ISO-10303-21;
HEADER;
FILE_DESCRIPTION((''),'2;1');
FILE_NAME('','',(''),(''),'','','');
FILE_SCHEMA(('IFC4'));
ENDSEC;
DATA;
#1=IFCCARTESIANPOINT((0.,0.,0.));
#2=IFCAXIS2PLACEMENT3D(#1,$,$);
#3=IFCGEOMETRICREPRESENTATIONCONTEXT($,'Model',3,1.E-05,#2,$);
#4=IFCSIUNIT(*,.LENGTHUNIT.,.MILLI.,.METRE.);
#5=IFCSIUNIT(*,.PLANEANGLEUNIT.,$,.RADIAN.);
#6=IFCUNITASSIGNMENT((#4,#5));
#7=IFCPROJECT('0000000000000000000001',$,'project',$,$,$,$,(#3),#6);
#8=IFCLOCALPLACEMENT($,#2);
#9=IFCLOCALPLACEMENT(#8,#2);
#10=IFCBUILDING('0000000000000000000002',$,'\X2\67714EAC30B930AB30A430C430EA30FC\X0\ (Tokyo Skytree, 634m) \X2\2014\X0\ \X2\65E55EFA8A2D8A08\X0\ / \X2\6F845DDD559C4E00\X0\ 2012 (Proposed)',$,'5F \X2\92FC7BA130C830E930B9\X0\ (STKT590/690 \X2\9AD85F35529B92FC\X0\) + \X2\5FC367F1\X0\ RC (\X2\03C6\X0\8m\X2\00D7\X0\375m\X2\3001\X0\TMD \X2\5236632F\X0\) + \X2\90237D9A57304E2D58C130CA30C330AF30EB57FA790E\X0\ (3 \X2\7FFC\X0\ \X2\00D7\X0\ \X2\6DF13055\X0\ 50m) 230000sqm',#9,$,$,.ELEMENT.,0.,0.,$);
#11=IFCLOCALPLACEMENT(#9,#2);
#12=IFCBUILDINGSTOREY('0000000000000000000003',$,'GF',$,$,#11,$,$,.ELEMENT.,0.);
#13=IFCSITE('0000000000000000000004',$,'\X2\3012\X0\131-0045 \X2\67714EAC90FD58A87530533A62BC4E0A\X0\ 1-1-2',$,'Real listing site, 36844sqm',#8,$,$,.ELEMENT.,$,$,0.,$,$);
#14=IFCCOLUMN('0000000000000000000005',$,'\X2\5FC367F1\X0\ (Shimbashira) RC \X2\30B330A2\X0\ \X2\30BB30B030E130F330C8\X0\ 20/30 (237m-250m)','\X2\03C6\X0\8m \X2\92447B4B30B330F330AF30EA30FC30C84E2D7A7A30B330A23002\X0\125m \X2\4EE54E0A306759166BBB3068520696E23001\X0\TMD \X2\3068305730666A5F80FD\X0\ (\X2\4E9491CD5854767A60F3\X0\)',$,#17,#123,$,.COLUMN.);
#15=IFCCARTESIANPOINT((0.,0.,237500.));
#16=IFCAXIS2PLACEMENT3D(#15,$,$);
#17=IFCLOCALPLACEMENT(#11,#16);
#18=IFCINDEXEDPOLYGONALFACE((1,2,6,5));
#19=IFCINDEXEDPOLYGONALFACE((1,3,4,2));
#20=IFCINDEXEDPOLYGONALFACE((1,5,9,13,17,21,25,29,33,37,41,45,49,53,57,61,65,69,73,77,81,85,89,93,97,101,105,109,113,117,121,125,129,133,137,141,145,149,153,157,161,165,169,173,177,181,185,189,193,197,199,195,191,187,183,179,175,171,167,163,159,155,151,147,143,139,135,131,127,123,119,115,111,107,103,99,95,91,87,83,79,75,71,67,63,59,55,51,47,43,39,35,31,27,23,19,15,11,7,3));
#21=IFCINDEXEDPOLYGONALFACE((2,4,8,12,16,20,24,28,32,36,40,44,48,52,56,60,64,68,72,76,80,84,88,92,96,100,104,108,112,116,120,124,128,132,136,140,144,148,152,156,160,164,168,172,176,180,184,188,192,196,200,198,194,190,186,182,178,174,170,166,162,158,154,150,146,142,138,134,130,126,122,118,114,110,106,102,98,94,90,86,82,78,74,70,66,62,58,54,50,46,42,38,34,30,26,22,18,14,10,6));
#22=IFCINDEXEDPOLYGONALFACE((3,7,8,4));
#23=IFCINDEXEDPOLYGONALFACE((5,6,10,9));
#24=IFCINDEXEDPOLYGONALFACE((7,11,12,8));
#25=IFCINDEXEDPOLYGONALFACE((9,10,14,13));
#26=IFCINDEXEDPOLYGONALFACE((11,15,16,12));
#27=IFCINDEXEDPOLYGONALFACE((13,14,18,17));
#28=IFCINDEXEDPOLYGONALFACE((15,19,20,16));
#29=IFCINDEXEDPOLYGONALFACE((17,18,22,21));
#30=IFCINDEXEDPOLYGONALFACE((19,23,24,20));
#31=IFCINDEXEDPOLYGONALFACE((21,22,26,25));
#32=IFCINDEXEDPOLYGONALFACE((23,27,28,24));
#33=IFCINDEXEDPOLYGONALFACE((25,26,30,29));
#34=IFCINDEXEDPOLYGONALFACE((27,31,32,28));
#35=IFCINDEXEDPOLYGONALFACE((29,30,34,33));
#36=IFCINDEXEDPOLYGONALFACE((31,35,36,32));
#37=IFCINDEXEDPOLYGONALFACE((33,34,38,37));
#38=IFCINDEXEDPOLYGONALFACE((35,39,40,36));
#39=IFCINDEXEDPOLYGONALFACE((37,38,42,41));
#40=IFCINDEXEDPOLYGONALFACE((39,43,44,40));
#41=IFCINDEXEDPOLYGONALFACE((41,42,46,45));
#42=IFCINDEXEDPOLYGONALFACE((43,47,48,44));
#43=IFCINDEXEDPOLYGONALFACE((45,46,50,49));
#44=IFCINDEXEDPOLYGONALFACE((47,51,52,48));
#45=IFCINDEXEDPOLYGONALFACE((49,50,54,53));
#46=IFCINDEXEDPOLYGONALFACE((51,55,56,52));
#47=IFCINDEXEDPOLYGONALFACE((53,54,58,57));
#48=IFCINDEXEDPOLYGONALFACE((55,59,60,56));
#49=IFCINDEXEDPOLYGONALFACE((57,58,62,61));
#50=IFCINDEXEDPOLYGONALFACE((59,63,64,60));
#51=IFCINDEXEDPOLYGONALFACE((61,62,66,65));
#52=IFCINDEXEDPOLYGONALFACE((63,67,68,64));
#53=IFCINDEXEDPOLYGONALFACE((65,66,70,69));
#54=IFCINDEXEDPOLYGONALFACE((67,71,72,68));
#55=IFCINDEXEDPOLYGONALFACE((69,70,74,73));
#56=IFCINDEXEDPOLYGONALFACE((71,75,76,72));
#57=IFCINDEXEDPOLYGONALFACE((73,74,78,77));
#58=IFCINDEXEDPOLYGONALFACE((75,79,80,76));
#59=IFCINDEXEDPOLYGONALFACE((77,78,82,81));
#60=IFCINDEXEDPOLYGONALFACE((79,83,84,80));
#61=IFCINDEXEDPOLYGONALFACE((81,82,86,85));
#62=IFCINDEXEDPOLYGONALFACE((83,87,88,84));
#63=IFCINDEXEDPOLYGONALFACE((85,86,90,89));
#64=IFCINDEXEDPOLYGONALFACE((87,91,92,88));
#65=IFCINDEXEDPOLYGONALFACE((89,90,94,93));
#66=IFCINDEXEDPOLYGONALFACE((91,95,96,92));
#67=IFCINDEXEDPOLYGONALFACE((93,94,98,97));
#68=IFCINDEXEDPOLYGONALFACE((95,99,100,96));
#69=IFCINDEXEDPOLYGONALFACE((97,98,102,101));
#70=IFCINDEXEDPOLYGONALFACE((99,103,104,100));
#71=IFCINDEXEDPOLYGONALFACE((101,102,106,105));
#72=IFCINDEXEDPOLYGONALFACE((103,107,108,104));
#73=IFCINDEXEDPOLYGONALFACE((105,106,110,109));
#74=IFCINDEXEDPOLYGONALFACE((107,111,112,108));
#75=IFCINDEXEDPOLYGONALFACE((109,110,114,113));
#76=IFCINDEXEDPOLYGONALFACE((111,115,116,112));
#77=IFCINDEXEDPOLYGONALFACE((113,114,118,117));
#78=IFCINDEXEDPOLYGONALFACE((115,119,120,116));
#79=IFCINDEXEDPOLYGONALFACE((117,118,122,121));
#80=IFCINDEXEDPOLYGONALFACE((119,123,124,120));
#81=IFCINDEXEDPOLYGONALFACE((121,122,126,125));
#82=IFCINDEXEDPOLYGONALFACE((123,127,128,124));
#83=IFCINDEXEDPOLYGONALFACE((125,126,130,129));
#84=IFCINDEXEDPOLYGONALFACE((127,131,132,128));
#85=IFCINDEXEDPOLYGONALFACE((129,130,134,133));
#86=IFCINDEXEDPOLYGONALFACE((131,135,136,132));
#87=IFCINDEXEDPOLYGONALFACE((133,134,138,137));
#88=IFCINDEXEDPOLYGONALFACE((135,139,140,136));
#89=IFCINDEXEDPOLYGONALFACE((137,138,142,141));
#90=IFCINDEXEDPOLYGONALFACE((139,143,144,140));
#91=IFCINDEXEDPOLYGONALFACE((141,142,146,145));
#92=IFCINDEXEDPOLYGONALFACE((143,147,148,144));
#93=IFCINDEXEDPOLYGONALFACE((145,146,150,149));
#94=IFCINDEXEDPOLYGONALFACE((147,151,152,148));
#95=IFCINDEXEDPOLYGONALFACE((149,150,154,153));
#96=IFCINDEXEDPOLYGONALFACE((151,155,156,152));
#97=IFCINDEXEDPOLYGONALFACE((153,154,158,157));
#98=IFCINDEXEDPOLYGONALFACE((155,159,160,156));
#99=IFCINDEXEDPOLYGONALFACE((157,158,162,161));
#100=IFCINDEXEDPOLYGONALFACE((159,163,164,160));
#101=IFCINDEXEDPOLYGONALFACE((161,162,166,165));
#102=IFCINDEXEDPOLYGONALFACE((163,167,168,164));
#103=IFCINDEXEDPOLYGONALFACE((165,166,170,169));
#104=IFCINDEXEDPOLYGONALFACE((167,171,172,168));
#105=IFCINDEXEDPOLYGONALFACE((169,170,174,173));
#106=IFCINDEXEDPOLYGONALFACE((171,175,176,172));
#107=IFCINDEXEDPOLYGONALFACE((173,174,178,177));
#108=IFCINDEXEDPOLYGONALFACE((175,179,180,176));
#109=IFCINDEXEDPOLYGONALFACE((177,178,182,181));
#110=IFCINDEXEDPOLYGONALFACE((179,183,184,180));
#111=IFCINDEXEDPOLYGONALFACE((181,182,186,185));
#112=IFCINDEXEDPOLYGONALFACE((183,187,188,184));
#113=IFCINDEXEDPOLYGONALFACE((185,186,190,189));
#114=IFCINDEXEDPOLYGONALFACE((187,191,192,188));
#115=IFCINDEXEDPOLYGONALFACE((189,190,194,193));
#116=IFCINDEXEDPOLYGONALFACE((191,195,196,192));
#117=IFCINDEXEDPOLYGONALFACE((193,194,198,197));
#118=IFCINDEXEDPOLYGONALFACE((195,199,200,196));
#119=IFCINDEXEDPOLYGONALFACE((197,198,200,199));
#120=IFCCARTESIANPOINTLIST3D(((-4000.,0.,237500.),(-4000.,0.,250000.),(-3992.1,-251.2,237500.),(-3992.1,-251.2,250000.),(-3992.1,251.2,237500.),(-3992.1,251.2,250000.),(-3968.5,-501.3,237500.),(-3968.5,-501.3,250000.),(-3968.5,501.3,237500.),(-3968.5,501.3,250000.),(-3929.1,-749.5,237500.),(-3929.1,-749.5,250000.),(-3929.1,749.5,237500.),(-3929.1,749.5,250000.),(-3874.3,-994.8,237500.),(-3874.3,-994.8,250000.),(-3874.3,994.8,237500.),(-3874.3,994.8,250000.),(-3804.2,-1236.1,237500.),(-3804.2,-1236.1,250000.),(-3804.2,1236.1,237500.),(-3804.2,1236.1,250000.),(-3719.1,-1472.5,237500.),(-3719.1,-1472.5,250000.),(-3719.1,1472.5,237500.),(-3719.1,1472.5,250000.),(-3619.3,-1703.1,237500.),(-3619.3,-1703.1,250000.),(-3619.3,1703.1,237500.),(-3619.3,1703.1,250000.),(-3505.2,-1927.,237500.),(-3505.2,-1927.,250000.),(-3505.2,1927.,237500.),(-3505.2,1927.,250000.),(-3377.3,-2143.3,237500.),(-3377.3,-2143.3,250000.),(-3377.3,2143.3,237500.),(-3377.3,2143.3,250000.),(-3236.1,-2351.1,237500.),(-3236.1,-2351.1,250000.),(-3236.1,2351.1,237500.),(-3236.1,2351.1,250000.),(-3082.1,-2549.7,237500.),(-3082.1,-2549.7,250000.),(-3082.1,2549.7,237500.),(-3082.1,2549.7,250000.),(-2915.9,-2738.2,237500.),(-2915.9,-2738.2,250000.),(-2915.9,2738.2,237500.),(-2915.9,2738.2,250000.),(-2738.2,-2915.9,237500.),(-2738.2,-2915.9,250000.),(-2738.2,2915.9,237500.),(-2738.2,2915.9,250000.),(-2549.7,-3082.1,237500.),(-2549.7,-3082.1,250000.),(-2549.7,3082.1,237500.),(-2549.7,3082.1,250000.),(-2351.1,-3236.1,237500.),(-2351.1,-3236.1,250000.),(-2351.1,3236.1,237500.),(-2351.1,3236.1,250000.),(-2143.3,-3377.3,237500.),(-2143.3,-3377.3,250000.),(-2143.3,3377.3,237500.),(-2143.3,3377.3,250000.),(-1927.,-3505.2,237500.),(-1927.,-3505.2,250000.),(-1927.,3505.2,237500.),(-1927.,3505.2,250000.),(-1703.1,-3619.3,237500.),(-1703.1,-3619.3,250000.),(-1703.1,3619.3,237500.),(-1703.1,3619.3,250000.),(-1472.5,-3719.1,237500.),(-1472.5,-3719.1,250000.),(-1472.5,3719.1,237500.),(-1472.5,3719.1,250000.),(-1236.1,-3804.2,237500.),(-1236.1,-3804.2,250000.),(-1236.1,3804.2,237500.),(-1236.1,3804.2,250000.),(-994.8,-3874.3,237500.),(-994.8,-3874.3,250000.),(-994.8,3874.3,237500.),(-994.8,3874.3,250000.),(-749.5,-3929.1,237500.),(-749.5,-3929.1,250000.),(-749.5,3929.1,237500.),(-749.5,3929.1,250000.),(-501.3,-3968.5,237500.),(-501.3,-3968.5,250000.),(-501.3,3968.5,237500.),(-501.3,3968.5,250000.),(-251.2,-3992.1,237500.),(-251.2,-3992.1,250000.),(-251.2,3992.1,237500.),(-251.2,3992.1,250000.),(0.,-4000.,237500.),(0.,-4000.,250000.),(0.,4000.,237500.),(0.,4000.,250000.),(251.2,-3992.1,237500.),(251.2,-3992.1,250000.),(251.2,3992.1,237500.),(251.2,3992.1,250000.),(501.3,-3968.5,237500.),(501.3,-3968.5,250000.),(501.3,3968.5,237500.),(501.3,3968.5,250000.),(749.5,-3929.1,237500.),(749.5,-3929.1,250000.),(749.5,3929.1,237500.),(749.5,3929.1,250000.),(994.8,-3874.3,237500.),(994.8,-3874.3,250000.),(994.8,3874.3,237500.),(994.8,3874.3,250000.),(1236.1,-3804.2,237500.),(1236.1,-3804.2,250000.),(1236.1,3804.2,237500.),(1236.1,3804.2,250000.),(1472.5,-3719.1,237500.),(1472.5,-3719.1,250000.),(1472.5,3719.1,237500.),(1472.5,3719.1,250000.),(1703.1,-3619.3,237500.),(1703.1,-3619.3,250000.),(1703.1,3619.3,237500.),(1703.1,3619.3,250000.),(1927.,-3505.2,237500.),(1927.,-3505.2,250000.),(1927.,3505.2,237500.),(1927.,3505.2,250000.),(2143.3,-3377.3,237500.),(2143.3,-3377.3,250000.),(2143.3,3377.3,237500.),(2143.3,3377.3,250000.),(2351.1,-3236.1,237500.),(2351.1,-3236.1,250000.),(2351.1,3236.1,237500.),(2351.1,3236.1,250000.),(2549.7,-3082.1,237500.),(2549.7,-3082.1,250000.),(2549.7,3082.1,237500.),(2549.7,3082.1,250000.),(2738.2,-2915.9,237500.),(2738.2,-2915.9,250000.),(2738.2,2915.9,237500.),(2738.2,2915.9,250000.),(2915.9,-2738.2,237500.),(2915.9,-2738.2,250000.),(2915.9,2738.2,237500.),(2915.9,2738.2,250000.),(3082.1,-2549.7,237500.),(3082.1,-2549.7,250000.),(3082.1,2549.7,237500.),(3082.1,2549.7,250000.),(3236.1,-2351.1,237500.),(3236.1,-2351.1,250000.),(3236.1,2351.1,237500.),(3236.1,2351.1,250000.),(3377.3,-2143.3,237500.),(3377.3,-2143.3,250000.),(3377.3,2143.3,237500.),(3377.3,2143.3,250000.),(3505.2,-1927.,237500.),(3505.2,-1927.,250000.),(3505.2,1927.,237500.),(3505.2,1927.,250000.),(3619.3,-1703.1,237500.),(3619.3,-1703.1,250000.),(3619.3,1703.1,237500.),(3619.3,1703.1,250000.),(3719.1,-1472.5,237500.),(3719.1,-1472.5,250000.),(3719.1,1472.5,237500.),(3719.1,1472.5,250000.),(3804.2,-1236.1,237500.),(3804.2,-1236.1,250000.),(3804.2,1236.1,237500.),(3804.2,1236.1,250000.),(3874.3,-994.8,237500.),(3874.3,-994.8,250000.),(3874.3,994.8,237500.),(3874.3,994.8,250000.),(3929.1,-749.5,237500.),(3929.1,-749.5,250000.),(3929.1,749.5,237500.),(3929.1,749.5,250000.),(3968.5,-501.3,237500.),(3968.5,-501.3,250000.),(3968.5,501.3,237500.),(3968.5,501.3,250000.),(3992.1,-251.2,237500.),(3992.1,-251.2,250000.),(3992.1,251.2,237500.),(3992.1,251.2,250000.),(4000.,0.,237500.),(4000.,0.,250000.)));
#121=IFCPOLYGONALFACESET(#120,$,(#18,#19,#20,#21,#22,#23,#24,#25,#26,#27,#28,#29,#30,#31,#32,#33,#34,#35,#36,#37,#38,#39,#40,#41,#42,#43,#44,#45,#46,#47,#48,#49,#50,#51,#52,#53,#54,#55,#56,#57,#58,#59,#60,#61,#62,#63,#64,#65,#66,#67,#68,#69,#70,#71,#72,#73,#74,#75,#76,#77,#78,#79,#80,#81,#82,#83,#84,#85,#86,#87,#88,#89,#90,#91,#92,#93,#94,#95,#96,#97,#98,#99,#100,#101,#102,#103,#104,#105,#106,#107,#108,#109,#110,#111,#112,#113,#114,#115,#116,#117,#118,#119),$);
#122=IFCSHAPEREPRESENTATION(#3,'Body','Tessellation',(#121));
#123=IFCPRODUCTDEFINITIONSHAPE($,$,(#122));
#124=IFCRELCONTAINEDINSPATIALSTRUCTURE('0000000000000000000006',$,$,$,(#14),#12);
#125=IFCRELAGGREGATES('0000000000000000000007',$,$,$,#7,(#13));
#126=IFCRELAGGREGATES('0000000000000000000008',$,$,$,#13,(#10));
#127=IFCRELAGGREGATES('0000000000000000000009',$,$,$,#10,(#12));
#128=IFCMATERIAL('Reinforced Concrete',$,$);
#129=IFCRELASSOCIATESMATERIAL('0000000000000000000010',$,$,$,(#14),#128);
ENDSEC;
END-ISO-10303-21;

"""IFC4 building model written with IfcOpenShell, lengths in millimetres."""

from ifc_helpers import new_model, si_unit, frame, origin, origin_2d, place, context, project, spatial, circle, extrude, material, element, save


model = new_model("IFC4")

# Units and contexts
model_context = context("Model", 3, precision=1e-05, world=origin())
ifc_project = project(units=[si_unit("LENGTHUNIT", "METRE", prefix="MILLI"), si_unit("PLANEANGLEUNIT", "RADIAN")], contexts=[model_context])

# Site, building, storey
site_placement = place(None, origin())
site = spatial("IfcSite", under=ifc_project, at=site_placement, Name="〒131-0045 東京都墨田区押上 1-1-2", ObjectType="Real listing site, 36844sqm", CompositionType="ELEMENT", RefElevation=0.0)
building_placement = place(site_placement, origin())
building = spatial("IfcBuilding", under=site, at=building_placement, Name="東京スカイツリー (Tokyo Skytree, 634m) — 日建設計 / 澄川喜一 2012 (Proposed)", ObjectType="5F 鋼管トラス (STKT590/690 高張力鋼) + 心柱 RC (φ8m×375m、TMD 制振) + 連続地中壁ナックル基礎 (3 翼 × 深さ 50m) 230000sqm", CompositionType="ELEMENT", ElevationOfRefHeight=0.0, ElevationOfTerrain=0.0)
storey_placement = place(building_placement, origin())
storey = spatial("IfcBuildingStorey", under=building, at=storey_placement, Name="GF", CompositionType="ELEMENT", Elevation=0.0)

# Column
ifc_material_1 = material(Name="Reinforced Concrete")
column_1_placement = place(storey_placement, frame((0.0, 0.0, 237500.0)))
element("IfcColumn", 1, at=column_1_placement, inside=storey, material=ifc_material_1, Name="心柱 (Shimbashira) RC コア セグメント 20/30 (237m-250m)", Description="φ8m 鉄筋コンクリート中空コア。125m 以上で外殻と分離、TMD として機能 (五重塔発想)", PredefinedType="COLUMN", context=model_context, shape_type="SweptSolid", body=[
    extrude(circle(Radius=4000.0, at=origin_2d()), frame((0.0, 0.0, 237500.0)), (0.0, 0.0, 1.0), 12500.0),
])

save(model, "model.ifc")
